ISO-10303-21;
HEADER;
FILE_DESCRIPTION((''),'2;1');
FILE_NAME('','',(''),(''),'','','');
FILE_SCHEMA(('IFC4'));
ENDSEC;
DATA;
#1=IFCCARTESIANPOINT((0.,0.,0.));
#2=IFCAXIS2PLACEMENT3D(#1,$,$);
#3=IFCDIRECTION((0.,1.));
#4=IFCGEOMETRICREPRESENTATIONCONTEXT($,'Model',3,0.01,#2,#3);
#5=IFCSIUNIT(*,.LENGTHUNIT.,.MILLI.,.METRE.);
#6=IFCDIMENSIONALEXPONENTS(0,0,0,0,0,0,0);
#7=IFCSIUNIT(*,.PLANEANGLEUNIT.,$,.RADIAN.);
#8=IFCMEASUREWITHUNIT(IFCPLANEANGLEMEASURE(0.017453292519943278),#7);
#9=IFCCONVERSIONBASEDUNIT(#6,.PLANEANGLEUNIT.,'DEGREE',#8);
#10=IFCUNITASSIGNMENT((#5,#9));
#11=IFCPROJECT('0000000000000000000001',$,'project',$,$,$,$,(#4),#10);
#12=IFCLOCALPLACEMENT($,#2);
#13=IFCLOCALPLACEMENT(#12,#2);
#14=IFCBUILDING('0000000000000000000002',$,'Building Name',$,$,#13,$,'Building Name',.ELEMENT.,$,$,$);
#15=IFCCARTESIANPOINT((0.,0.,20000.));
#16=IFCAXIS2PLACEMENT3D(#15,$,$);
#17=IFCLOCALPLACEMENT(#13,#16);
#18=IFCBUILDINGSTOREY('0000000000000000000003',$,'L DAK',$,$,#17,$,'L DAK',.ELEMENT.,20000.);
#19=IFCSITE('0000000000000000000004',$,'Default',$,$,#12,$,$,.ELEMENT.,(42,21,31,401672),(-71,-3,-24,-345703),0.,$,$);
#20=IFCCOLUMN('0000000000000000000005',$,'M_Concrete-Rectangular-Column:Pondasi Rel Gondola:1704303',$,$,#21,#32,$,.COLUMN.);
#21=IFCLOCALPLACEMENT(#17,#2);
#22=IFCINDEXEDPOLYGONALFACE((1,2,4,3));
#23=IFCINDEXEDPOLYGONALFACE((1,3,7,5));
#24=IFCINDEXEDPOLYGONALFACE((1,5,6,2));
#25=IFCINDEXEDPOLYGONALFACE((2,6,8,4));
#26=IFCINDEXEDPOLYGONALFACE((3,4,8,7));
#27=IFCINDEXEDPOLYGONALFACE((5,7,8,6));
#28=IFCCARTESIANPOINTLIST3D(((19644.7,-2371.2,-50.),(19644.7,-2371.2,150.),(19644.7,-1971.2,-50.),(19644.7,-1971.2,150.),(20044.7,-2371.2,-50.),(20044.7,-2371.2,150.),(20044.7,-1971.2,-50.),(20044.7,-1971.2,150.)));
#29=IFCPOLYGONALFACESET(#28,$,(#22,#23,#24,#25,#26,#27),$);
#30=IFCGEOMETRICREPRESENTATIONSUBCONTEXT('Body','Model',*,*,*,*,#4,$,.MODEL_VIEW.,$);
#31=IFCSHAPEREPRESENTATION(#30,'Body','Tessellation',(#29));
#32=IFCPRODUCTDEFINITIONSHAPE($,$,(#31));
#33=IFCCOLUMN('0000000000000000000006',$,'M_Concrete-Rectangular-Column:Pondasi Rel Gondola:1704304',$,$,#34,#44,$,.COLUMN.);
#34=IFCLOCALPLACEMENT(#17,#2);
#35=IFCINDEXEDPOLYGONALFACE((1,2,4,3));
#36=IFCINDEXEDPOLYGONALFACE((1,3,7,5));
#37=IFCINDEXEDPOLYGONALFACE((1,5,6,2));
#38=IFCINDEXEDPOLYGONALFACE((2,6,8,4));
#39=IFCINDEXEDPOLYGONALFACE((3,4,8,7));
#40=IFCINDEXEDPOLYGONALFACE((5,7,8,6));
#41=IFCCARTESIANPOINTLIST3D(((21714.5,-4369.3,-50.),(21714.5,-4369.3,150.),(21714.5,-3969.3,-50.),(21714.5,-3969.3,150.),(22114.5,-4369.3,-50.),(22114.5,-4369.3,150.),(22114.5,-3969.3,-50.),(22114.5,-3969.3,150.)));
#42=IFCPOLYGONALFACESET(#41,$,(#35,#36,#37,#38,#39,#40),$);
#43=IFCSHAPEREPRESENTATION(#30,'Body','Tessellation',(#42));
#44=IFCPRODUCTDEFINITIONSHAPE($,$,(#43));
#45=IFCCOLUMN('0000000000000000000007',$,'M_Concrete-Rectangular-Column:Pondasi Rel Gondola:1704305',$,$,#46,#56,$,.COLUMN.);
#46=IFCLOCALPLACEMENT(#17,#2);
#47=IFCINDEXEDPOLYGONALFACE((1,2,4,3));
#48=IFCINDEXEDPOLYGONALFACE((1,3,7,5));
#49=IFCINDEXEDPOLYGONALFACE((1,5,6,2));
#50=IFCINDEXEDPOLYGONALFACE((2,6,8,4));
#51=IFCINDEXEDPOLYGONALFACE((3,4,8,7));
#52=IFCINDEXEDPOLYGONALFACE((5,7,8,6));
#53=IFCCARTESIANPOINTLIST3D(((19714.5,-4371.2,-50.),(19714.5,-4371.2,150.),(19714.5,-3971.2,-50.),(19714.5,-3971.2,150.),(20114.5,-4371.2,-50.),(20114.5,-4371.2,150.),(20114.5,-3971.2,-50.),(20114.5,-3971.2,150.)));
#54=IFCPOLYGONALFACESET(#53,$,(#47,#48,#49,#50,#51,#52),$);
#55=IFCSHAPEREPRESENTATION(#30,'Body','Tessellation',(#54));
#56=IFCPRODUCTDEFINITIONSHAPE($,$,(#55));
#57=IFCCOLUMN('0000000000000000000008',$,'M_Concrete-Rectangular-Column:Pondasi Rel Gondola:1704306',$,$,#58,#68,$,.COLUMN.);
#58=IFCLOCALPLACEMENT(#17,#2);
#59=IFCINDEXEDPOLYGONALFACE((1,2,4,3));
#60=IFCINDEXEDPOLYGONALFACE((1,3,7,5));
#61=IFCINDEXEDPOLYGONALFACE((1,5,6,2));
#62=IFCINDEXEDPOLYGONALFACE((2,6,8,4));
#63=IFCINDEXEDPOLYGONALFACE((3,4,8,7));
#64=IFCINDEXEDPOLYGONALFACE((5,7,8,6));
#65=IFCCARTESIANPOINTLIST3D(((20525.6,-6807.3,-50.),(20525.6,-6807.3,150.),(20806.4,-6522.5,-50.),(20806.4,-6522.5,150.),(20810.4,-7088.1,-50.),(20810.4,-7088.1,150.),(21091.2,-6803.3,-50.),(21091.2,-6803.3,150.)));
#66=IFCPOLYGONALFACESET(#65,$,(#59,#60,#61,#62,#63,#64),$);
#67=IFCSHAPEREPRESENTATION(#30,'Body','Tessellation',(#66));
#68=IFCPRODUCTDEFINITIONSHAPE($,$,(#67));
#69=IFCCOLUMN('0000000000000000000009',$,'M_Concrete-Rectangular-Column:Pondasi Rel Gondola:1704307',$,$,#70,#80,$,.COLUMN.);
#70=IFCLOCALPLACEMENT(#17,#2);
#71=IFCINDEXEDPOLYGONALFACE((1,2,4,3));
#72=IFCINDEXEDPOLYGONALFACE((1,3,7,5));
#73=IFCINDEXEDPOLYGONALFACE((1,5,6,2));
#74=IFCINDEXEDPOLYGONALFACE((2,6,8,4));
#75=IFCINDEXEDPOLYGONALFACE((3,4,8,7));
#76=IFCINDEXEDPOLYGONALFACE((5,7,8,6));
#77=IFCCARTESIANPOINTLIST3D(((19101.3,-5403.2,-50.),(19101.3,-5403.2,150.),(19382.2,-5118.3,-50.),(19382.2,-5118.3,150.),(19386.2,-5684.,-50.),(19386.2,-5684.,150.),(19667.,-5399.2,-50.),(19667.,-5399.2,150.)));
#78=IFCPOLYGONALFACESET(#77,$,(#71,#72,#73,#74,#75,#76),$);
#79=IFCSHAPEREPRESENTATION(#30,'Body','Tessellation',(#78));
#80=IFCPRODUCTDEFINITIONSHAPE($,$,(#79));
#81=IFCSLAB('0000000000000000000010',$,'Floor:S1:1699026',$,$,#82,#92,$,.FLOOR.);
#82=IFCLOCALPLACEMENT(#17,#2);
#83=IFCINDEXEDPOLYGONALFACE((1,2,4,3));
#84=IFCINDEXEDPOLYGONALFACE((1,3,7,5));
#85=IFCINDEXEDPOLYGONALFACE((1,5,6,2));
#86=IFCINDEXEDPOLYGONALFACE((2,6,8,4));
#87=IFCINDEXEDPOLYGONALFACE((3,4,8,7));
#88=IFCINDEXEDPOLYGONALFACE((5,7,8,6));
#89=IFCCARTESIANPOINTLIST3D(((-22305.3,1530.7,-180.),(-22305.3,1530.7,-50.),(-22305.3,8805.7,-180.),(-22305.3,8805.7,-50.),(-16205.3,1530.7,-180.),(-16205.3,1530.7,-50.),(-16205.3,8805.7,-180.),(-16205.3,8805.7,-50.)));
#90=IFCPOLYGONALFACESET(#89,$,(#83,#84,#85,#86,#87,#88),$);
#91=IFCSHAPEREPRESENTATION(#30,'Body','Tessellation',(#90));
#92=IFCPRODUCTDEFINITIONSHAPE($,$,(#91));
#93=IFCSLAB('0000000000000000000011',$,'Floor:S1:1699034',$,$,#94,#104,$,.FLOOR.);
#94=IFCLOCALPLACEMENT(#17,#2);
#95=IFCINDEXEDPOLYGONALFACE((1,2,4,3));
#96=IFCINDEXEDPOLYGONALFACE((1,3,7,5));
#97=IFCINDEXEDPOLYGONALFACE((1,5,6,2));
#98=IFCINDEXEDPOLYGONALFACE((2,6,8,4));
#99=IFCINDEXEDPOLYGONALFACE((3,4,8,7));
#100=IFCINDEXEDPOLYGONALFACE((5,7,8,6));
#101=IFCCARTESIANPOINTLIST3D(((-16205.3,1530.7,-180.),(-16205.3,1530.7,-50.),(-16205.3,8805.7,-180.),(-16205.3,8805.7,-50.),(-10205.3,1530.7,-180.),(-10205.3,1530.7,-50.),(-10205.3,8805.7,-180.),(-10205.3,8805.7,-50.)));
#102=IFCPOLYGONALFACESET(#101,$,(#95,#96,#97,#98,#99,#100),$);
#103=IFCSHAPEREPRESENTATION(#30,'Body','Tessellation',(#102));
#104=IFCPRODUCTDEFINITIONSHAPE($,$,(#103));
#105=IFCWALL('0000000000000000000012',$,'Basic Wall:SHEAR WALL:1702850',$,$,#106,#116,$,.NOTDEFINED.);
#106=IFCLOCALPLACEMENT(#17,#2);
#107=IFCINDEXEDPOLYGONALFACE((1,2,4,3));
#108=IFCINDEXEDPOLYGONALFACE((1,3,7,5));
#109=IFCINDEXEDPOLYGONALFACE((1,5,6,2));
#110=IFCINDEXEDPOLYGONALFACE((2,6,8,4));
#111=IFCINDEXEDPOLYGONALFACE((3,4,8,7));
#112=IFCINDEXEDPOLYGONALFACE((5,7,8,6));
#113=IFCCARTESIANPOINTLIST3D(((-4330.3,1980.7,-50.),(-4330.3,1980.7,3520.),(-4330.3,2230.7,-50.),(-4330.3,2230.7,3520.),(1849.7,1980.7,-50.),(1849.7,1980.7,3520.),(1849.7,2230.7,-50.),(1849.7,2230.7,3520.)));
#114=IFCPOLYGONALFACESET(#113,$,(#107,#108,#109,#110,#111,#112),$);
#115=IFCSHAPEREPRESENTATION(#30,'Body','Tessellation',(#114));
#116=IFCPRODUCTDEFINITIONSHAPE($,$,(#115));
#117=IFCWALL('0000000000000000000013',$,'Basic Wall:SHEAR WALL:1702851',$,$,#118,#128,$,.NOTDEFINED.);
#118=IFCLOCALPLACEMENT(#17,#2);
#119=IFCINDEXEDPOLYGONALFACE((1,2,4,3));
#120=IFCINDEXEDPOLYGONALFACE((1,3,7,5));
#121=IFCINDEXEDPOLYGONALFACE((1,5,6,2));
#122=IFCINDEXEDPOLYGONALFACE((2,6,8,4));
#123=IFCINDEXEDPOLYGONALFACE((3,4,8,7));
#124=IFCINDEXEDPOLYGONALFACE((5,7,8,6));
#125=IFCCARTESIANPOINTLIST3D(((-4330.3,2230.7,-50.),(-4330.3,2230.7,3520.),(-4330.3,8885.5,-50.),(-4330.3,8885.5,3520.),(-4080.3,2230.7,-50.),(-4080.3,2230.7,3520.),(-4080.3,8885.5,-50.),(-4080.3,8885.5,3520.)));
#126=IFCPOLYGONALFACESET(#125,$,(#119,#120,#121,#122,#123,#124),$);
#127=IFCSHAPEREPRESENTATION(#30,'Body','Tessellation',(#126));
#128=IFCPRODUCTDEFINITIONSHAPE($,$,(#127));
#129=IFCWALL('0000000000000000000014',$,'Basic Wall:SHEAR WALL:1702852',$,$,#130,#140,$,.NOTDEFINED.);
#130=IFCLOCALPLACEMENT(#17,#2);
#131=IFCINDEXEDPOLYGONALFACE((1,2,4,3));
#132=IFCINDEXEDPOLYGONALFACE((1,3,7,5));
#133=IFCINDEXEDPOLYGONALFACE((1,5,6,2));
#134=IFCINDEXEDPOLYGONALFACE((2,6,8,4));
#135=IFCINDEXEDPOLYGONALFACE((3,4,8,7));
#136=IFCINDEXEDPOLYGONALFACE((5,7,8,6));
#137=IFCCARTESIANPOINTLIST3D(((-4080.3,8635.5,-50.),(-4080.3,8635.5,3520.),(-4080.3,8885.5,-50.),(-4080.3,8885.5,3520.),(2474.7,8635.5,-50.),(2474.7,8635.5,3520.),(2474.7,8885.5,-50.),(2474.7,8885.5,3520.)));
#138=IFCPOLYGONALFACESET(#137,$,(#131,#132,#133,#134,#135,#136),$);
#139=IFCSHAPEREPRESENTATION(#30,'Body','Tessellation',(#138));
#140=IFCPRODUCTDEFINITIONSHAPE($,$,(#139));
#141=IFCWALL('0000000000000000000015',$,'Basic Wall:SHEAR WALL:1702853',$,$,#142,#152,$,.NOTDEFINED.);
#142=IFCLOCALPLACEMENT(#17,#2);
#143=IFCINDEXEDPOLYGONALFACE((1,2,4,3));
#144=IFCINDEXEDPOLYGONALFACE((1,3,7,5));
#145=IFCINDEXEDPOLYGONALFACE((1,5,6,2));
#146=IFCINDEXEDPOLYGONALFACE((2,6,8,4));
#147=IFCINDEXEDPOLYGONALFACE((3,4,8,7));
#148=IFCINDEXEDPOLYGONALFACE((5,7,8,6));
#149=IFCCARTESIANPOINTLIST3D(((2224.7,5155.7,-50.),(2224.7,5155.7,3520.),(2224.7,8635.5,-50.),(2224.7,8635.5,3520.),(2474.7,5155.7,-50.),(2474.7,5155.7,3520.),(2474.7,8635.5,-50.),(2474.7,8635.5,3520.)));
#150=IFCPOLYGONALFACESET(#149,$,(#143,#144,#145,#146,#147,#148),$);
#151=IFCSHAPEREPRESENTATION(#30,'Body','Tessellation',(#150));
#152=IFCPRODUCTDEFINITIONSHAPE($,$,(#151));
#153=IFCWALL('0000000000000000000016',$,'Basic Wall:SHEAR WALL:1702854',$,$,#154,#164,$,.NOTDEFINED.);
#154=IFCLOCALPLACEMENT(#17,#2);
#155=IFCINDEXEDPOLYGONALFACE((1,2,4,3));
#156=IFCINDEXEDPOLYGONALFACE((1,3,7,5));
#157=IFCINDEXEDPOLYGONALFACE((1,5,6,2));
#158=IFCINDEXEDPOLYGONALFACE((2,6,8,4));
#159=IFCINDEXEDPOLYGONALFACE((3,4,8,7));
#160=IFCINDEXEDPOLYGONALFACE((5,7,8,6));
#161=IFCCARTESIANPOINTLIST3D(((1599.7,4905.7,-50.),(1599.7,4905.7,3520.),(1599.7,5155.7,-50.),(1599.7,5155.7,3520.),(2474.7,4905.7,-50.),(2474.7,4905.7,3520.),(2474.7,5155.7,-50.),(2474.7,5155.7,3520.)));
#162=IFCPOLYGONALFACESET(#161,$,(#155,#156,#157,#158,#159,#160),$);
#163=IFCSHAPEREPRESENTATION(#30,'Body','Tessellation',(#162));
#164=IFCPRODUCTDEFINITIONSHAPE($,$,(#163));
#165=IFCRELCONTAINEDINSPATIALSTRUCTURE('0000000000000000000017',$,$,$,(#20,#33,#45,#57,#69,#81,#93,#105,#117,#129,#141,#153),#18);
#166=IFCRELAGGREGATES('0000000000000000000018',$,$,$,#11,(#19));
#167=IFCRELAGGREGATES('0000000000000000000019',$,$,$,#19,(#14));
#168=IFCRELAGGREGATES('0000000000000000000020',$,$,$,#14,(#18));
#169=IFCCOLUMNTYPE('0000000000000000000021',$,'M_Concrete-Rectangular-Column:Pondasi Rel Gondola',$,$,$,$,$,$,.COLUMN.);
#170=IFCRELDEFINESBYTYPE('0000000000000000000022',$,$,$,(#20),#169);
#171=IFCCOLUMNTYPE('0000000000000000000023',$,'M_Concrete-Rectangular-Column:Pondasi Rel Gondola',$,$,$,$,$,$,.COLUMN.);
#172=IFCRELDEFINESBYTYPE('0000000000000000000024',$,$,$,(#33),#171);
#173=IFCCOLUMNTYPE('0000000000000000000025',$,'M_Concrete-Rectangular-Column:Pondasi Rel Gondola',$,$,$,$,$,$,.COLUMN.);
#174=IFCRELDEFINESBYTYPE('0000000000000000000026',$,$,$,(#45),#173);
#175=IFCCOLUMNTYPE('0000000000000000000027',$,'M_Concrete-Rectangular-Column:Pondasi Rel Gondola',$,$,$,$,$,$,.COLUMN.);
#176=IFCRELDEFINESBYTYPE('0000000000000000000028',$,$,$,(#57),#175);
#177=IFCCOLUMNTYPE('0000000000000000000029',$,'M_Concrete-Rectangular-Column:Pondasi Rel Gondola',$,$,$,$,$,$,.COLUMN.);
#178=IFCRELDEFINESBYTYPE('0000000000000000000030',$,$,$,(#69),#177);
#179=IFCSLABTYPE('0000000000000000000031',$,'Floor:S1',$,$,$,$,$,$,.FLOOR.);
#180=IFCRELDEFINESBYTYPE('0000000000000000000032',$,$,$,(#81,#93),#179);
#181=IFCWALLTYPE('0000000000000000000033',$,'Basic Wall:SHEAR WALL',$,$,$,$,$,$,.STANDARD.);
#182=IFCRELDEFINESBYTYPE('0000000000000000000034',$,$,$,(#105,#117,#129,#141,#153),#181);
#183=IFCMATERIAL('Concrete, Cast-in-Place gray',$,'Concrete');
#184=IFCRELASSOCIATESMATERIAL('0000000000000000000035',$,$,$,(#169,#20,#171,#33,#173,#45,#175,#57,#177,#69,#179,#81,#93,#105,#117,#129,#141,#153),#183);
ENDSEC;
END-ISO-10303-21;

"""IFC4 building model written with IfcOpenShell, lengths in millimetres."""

from ifc_helpers import new_model, entity, si_unit, converted_unit, direction, frame, origin, place, context, subcontext, project, spatial, indexed_curve, outline, extrude, source, transform, mapped, material, type_object, type_shapes, element, save


model = new_model("IFC4")

# Units and contexts
model_context = context("Model", 3, precision=0.01, world=origin(), true_north=direction((0.0, 1.0)))
body_context = subcontext(model_context, "Body", "Model", "MODEL_VIEW")
ifc_project = project(units=[si_unit("LENGTHUNIT", "METRE", prefix="MILLI"), converted_unit("PLANEANGLEUNIT", "DEGREE", entity("IfcPlaneAngleMeasure", 0.017453292519943278), si_unit("PLANEANGLEUNIT", "RADIAN"), dimensions=[0, 0, 0, 0, 0, 0, 0])], contexts=[model_context])

# Site, building, storey
site_placement = place(None, origin())
site = spatial("IfcSite", under=ifc_project, at=site_placement, Name="Default", CompositionType="ELEMENT", RefLatitude=(42, 21, 31, 401672), RefLongitude=(-71, -3, -24, -345703), RefElevation=0.0)
building_placement = place(site_placement, origin())
building = spatial("IfcBuilding", under=site, at=building_placement, Name="Building Name", LongName="Building Name", CompositionType="ELEMENT")
storey_placement = place(building_placement, frame((0.0, 0.0, 20000.0)))
storey = spatial("IfcBuildingStorey", under=building, at=storey_placement, Name="L DAK", LongName="L DAK", CompositionType="ELEMENT", Elevation=20000.0)

# Columns
ifc_material = material(Name="Concrete, Cast-in-Place gray", Category="Concrete")
column_type_1 = type_object("IfcColumnType", Name="M_Concrete-Rectangular-Column:Pondasi Rel Gondola", PredefinedType="COLUMN", material=ifc_material)
shared_shape_1 = source(origin(), body_context, "Body", "SweptSolid", [
    extrude(outline(indexed_curve([(-200.0, -200.0), (200.0, -200.0), (200.0, 200.0), (-200.0, 200.0), (-200.0, -200.0)], self_intersect=False)), frame((19844.7, -2171.2, 19950.0), z_axis=(0.0, 0.0, 1.0), x_axis=(0.0, -1.0, 0.0)), (0.0, 0.0, 1.0), 200.0),
])
type_shapes(column_type_1, [shared_shape_1])
column_1_placement = place(storey_placement, frame((0.0, 0.0, -20000.0)))
element("IfcColumn", 1, at=column_1_placement, inside=storey, type_object=column_type_1, material=ifc_material, Name="M_Concrete-Rectangular-Column:Pondasi Rel Gondola:1704303", PredefinedType="COLUMN", context=body_context, shape_type="MappedRepresentation", body=[
    mapped(shared_shape_1, transform((0.0, 0.0, 0.0), scale=1.0)),
])
column_type_2 = type_object("IfcColumnType", Name="M_Concrete-Rectangular-Column:Pondasi Rel Gondola", PredefinedType="COLUMN", material=ifc_material)
shared_shape_2 = source(origin(), body_context, "Body", "SweptSolid", [
    extrude(outline(indexed_curve([(-200.0, -200.0), (200.0, -200.0), (200.0, 200.0), (-200.0, 200.0), (-200.0, -200.0)], self_intersect=False)), frame((21914.5, -4169.3, 19950.0), z_axis=(0.0, 0.0, 1.0), x_axis=(0.0, -1.0, 0.0)), (0.0, 0.0, 1.0), 200.0),
])
type_shapes(column_type_2, [shared_shape_2])
column_2_placement = place(storey_placement, frame((0.0, 0.0, -20000.0)))
element("IfcColumn", 2, at=column_2_placement, inside=storey, type_object=column_type_2, material=ifc_material, Name="M_Concrete-Rectangular-Column:Pondasi Rel Gondola:1704304", PredefinedType="COLUMN", context=body_context, shape_type="MappedRepresentation", body=[
    mapped(shared_shape_2, transform((0.0, 0.0, 0.0), scale=1.0)),
])
column_type_3 = type_object("IfcColumnType", Name="M_Concrete-Rectangular-Column:Pondasi Rel Gondola", PredefinedType="COLUMN", material=ifc_material)
shared_shape_3 = source(origin(), body_context, "Body", "SweptSolid", [
    extrude(outline(indexed_curve([(-200.0, -200.0), (200.0, -200.0), (200.0, 200.0), (-200.0, 200.0), (-200.0, -200.0)], self_intersect=False)), frame((19914.5, -4171.2, 19950.0), z_axis=(0.0, 0.0, 1.0), x_axis=(0.0, -1.0, 0.0)), (0.0, 0.0, 1.0), 200.0),
])
type_shapes(column_type_3, [shared_shape_3])
column_3_placement = place(storey_placement, frame((0.0, 0.0, -20000.0)))
element("IfcColumn", 3, at=column_3_placement, inside=storey, type_object=column_type_3, material=ifc_material, Name="M_Concrete-Rectangular-Column:Pondasi Rel Gondola:1704305", PredefinedType="COLUMN", context=body_context, shape_type="MappedRepresentation", body=[
    mapped(shared_shape_3, transform((0.0, 0.0, 0.0), scale=1.0)),
])
column_type_4 = type_object("IfcColumnType", Name="M_Concrete-Rectangular-Column:Pondasi Rel Gondola", PredefinedType="COLUMN", material=ifc_material)
shared_shape_4 = source(origin(), body_context, "Body", "SweptSolid", [
    extrude(outline(indexed_curve([(-200.0, -200.0), (200.0, -200.0), (200.0, 200.0), (-200.0, 200.0), (-200.0, -200.0)], self_intersect=False)), frame((20808.4, -6805.3, 19950.0), z_axis=(0.0, 0.0, 1.0), x_axis=(0.702064, 0.712114, 0.0)), (0.0, 0.0, 1.0), 200.0),
])
type_shapes(column_type_4, [shared_shape_4])
column_4_placement = place(storey_placement, frame((0.0, 0.0, -20000.0)))
element("IfcColumn", 4, at=column_4_placement, inside=storey, type_object=column_type_4, material=ifc_material, Name="M_Concrete-Rectangular-Column:Pondasi Rel Gondola:1704306", PredefinedType="COLUMN", context=body_context, shape_type="MappedRepresentation", body=[
    mapped(shared_shape_4, transform((0.0, 0.0, 0.0), scale=1.0)),
])
column_type_5 = type_object("IfcColumnType", Name="M_Concrete-Rectangular-Column:Pondasi Rel Gondola", PredefinedType="COLUMN", material=ifc_material)
shared_shape_5 = source(origin(), body_context, "Body", "SweptSolid", [
    extrude(outline(indexed_curve([(-200.0, -200.0), (200.0, -200.0), (200.0, 200.0), (-200.0, 200.0), (-200.0, -200.0)], self_intersect=False)), frame((19384.2, -5401.2, 19950.0), z_axis=(0.0, 0.0, 1.0), x_axis=(0.702064, 0.712114, 0.0)), (0.0, 0.0, 1.0), 200.0),
])
type_shapes(column_type_5, [shared_shape_5])
column_5_placement = place(storey_placement, frame((0.0, 0.0, -20000.0)))
element("IfcColumn", 5, at=column_5_placement, inside=storey, type_object=column_type_5, material=ifc_material, Name="M_Concrete-Rectangular-Column:Pondasi Rel Gondola:1704307", PredefinedType="COLUMN", context=body_context, shape_type="MappedRepresentation", body=[
    mapped(shared_shape_5, transform((0.0, 0.0, 0.0), scale=1.0)),
])

# Slabs
slab_type = type_object("IfcSlabType", Name="Floor:S1", PredefinedType="FLOOR", material=ifc_material)
slab_1_placement = place(storey_placement, origin())
element("IfcSlab", 6, at=slab_1_placement, inside=storey, type_object=slab_type, material=ifc_material, Name="Floor:S1:1699026", PredefinedType="FLOOR", context=body_context, shape_type="SweptSolid", body=[
    extrude(outline(indexed_curve([(-3637.5, -3050.0), (3637.5, -3050.0), (3637.5, 3050.0), (-3637.5, 3050.0), (-3637.5, -3050.0)], self_intersect=False)), frame((-19255.3, 5168.2, -50.0), z_axis=(0.0, 0.0, -1.0), x_axis=(0.0, 1.0, 0.0)), (0.0, 0.0, 1.0), 130.0),
])
slab_2_placement = place(storey_placement, origin())
element("IfcSlab", 7, at=slab_2_placement, inside=storey, type_object=slab_type, material=ifc_material, Name="Floor:S1:1699034", PredefinedType="FLOOR", context=body_context, shape_type="SweptSolid", body=[
    extrude(outline(indexed_curve([(-3637.5, -3000.0), (3637.5, -3000.0), (3637.5, 3000.0), (-3637.5, 3000.0), (-3637.5, -3000.0)], self_intersect=False)), frame((-13205.3, 5168.2, -50.0), z_axis=(0.0, 0.0, -1.0), x_axis=(0.0, 1.0, 0.0)), (0.0, 0.0, 1.0), 130.0),
])

# Walls
wall_type = type_object("IfcWallType", Name="Basic Wall:SHEAR WALL", PredefinedType="STANDARD")
wall_1_placement = place(storey_placement, frame((-4330.3, 2105.7, -50.0)))
element("IfcWall", 8, at=wall_1_placement, inside=storey, type_object=wall_type, material=ifc_material, Name="Basic Wall:SHEAR WALL:1702850", PredefinedType="NOTDEFINED", context=body_context, shape_type="SweptSolid", body=[
    extrude(outline(indexed_curve([(6180.0, 125.0), (0.0, 125.0), (0.0, -125.0), (6180.0, -125.0), (6180.0, 125.0)], self_intersect=False)), origin(), (0.0, 0.0, 1.0), 3570.0),
])
wall_2_placement = place(storey_placement, frame((-4205.3, 2230.7, -50.0), z_axis=(0.0, 0.0, 1.0), x_axis=(0.0, 1.0, 0.0)))
element("IfcWall", 9, at=wall_2_placement, inside=storey, type_object=wall_type, material=ifc_material, Name="Basic Wall:SHEAR WALL:1702851", PredefinedType="NOTDEFINED", context=body_context, shape_type="SweptSolid", body=[
    extrude(outline(indexed_curve([(6654.9, 125.0), (0.0, 125.0), (0.0, -125.0), (6654.9, -125.0), (6654.9, 125.0)], self_intersect=False)), origin(), (0.0, 0.0, 1.0), 3570.0),
])
wall_3_placement = place(storey_placement, frame((-4080.3, 8760.5, -50.0)))
element("IfcWall", 10, at=wall_3_placement, inside=storey, type_object=wall_type, material=ifc_material, Name="Basic Wall:SHEAR WALL:1702852", PredefinedType="NOTDEFINED", context=body_context, shape_type="SweptSolid", body=[
    extrude(outline(indexed_curve([(6555.0, 125.0), (0.0, 125.0), (0.0, -125.0), (6555.0, -125.0), (6555.0, 125.0)], self_intersect=False)), origin(), (0.0, 0.0, 1.0), 3570.0),
])
wall_4_placement = place(storey_placement, frame((2349.7, 8635.5, -50.0), z_axis=(0.0, 0.0, 1.0), x_axis=(0.0, -1.0, 0.0)))
element("IfcWall", 11, at=wall_4_placement, inside=storey, type_object=wall_type, material=ifc_material, Name="Basic Wall:SHEAR WALL:1702853", PredefinedType="NOTDEFINED", context=body_context, shape_type="SweptSolid", body=[
    extrude(outline(indexed_curve([(3479.9, 125.0), (0.0, 125.0), (0.0, -125.0), (3479.9, -125.0), (3479.9, 125.0)], self_intersect=False)), origin(), (0.0, 0.0, 1.0), 3570.0),
])
wall_5_placement = place(storey_placement, frame((2474.7, 5030.7, -50.0), z_axis=(0.0, 0.0, 1.0), x_axis=(-1.0, 0.0, 0.0)))
element("IfcWall", 12, at=wall_5_placement, inside=storey, type_object=wall_type, material=ifc_material, Name="Basic Wall:SHEAR WALL:1702854", PredefinedType="NOTDEFINED", context=body_context, shape_type="SweptSolid", body=[
    extrude(outline(indexed_curve([(875.0, 125.0), (0.0, 125.0), (0.0, -125.0), (875.0, -125.0), (875.0, 125.0)], self_intersect=False)), origin(), (0.0, 0.0, 1.0), 3570.0),
])

save(model, "model.ifc")
